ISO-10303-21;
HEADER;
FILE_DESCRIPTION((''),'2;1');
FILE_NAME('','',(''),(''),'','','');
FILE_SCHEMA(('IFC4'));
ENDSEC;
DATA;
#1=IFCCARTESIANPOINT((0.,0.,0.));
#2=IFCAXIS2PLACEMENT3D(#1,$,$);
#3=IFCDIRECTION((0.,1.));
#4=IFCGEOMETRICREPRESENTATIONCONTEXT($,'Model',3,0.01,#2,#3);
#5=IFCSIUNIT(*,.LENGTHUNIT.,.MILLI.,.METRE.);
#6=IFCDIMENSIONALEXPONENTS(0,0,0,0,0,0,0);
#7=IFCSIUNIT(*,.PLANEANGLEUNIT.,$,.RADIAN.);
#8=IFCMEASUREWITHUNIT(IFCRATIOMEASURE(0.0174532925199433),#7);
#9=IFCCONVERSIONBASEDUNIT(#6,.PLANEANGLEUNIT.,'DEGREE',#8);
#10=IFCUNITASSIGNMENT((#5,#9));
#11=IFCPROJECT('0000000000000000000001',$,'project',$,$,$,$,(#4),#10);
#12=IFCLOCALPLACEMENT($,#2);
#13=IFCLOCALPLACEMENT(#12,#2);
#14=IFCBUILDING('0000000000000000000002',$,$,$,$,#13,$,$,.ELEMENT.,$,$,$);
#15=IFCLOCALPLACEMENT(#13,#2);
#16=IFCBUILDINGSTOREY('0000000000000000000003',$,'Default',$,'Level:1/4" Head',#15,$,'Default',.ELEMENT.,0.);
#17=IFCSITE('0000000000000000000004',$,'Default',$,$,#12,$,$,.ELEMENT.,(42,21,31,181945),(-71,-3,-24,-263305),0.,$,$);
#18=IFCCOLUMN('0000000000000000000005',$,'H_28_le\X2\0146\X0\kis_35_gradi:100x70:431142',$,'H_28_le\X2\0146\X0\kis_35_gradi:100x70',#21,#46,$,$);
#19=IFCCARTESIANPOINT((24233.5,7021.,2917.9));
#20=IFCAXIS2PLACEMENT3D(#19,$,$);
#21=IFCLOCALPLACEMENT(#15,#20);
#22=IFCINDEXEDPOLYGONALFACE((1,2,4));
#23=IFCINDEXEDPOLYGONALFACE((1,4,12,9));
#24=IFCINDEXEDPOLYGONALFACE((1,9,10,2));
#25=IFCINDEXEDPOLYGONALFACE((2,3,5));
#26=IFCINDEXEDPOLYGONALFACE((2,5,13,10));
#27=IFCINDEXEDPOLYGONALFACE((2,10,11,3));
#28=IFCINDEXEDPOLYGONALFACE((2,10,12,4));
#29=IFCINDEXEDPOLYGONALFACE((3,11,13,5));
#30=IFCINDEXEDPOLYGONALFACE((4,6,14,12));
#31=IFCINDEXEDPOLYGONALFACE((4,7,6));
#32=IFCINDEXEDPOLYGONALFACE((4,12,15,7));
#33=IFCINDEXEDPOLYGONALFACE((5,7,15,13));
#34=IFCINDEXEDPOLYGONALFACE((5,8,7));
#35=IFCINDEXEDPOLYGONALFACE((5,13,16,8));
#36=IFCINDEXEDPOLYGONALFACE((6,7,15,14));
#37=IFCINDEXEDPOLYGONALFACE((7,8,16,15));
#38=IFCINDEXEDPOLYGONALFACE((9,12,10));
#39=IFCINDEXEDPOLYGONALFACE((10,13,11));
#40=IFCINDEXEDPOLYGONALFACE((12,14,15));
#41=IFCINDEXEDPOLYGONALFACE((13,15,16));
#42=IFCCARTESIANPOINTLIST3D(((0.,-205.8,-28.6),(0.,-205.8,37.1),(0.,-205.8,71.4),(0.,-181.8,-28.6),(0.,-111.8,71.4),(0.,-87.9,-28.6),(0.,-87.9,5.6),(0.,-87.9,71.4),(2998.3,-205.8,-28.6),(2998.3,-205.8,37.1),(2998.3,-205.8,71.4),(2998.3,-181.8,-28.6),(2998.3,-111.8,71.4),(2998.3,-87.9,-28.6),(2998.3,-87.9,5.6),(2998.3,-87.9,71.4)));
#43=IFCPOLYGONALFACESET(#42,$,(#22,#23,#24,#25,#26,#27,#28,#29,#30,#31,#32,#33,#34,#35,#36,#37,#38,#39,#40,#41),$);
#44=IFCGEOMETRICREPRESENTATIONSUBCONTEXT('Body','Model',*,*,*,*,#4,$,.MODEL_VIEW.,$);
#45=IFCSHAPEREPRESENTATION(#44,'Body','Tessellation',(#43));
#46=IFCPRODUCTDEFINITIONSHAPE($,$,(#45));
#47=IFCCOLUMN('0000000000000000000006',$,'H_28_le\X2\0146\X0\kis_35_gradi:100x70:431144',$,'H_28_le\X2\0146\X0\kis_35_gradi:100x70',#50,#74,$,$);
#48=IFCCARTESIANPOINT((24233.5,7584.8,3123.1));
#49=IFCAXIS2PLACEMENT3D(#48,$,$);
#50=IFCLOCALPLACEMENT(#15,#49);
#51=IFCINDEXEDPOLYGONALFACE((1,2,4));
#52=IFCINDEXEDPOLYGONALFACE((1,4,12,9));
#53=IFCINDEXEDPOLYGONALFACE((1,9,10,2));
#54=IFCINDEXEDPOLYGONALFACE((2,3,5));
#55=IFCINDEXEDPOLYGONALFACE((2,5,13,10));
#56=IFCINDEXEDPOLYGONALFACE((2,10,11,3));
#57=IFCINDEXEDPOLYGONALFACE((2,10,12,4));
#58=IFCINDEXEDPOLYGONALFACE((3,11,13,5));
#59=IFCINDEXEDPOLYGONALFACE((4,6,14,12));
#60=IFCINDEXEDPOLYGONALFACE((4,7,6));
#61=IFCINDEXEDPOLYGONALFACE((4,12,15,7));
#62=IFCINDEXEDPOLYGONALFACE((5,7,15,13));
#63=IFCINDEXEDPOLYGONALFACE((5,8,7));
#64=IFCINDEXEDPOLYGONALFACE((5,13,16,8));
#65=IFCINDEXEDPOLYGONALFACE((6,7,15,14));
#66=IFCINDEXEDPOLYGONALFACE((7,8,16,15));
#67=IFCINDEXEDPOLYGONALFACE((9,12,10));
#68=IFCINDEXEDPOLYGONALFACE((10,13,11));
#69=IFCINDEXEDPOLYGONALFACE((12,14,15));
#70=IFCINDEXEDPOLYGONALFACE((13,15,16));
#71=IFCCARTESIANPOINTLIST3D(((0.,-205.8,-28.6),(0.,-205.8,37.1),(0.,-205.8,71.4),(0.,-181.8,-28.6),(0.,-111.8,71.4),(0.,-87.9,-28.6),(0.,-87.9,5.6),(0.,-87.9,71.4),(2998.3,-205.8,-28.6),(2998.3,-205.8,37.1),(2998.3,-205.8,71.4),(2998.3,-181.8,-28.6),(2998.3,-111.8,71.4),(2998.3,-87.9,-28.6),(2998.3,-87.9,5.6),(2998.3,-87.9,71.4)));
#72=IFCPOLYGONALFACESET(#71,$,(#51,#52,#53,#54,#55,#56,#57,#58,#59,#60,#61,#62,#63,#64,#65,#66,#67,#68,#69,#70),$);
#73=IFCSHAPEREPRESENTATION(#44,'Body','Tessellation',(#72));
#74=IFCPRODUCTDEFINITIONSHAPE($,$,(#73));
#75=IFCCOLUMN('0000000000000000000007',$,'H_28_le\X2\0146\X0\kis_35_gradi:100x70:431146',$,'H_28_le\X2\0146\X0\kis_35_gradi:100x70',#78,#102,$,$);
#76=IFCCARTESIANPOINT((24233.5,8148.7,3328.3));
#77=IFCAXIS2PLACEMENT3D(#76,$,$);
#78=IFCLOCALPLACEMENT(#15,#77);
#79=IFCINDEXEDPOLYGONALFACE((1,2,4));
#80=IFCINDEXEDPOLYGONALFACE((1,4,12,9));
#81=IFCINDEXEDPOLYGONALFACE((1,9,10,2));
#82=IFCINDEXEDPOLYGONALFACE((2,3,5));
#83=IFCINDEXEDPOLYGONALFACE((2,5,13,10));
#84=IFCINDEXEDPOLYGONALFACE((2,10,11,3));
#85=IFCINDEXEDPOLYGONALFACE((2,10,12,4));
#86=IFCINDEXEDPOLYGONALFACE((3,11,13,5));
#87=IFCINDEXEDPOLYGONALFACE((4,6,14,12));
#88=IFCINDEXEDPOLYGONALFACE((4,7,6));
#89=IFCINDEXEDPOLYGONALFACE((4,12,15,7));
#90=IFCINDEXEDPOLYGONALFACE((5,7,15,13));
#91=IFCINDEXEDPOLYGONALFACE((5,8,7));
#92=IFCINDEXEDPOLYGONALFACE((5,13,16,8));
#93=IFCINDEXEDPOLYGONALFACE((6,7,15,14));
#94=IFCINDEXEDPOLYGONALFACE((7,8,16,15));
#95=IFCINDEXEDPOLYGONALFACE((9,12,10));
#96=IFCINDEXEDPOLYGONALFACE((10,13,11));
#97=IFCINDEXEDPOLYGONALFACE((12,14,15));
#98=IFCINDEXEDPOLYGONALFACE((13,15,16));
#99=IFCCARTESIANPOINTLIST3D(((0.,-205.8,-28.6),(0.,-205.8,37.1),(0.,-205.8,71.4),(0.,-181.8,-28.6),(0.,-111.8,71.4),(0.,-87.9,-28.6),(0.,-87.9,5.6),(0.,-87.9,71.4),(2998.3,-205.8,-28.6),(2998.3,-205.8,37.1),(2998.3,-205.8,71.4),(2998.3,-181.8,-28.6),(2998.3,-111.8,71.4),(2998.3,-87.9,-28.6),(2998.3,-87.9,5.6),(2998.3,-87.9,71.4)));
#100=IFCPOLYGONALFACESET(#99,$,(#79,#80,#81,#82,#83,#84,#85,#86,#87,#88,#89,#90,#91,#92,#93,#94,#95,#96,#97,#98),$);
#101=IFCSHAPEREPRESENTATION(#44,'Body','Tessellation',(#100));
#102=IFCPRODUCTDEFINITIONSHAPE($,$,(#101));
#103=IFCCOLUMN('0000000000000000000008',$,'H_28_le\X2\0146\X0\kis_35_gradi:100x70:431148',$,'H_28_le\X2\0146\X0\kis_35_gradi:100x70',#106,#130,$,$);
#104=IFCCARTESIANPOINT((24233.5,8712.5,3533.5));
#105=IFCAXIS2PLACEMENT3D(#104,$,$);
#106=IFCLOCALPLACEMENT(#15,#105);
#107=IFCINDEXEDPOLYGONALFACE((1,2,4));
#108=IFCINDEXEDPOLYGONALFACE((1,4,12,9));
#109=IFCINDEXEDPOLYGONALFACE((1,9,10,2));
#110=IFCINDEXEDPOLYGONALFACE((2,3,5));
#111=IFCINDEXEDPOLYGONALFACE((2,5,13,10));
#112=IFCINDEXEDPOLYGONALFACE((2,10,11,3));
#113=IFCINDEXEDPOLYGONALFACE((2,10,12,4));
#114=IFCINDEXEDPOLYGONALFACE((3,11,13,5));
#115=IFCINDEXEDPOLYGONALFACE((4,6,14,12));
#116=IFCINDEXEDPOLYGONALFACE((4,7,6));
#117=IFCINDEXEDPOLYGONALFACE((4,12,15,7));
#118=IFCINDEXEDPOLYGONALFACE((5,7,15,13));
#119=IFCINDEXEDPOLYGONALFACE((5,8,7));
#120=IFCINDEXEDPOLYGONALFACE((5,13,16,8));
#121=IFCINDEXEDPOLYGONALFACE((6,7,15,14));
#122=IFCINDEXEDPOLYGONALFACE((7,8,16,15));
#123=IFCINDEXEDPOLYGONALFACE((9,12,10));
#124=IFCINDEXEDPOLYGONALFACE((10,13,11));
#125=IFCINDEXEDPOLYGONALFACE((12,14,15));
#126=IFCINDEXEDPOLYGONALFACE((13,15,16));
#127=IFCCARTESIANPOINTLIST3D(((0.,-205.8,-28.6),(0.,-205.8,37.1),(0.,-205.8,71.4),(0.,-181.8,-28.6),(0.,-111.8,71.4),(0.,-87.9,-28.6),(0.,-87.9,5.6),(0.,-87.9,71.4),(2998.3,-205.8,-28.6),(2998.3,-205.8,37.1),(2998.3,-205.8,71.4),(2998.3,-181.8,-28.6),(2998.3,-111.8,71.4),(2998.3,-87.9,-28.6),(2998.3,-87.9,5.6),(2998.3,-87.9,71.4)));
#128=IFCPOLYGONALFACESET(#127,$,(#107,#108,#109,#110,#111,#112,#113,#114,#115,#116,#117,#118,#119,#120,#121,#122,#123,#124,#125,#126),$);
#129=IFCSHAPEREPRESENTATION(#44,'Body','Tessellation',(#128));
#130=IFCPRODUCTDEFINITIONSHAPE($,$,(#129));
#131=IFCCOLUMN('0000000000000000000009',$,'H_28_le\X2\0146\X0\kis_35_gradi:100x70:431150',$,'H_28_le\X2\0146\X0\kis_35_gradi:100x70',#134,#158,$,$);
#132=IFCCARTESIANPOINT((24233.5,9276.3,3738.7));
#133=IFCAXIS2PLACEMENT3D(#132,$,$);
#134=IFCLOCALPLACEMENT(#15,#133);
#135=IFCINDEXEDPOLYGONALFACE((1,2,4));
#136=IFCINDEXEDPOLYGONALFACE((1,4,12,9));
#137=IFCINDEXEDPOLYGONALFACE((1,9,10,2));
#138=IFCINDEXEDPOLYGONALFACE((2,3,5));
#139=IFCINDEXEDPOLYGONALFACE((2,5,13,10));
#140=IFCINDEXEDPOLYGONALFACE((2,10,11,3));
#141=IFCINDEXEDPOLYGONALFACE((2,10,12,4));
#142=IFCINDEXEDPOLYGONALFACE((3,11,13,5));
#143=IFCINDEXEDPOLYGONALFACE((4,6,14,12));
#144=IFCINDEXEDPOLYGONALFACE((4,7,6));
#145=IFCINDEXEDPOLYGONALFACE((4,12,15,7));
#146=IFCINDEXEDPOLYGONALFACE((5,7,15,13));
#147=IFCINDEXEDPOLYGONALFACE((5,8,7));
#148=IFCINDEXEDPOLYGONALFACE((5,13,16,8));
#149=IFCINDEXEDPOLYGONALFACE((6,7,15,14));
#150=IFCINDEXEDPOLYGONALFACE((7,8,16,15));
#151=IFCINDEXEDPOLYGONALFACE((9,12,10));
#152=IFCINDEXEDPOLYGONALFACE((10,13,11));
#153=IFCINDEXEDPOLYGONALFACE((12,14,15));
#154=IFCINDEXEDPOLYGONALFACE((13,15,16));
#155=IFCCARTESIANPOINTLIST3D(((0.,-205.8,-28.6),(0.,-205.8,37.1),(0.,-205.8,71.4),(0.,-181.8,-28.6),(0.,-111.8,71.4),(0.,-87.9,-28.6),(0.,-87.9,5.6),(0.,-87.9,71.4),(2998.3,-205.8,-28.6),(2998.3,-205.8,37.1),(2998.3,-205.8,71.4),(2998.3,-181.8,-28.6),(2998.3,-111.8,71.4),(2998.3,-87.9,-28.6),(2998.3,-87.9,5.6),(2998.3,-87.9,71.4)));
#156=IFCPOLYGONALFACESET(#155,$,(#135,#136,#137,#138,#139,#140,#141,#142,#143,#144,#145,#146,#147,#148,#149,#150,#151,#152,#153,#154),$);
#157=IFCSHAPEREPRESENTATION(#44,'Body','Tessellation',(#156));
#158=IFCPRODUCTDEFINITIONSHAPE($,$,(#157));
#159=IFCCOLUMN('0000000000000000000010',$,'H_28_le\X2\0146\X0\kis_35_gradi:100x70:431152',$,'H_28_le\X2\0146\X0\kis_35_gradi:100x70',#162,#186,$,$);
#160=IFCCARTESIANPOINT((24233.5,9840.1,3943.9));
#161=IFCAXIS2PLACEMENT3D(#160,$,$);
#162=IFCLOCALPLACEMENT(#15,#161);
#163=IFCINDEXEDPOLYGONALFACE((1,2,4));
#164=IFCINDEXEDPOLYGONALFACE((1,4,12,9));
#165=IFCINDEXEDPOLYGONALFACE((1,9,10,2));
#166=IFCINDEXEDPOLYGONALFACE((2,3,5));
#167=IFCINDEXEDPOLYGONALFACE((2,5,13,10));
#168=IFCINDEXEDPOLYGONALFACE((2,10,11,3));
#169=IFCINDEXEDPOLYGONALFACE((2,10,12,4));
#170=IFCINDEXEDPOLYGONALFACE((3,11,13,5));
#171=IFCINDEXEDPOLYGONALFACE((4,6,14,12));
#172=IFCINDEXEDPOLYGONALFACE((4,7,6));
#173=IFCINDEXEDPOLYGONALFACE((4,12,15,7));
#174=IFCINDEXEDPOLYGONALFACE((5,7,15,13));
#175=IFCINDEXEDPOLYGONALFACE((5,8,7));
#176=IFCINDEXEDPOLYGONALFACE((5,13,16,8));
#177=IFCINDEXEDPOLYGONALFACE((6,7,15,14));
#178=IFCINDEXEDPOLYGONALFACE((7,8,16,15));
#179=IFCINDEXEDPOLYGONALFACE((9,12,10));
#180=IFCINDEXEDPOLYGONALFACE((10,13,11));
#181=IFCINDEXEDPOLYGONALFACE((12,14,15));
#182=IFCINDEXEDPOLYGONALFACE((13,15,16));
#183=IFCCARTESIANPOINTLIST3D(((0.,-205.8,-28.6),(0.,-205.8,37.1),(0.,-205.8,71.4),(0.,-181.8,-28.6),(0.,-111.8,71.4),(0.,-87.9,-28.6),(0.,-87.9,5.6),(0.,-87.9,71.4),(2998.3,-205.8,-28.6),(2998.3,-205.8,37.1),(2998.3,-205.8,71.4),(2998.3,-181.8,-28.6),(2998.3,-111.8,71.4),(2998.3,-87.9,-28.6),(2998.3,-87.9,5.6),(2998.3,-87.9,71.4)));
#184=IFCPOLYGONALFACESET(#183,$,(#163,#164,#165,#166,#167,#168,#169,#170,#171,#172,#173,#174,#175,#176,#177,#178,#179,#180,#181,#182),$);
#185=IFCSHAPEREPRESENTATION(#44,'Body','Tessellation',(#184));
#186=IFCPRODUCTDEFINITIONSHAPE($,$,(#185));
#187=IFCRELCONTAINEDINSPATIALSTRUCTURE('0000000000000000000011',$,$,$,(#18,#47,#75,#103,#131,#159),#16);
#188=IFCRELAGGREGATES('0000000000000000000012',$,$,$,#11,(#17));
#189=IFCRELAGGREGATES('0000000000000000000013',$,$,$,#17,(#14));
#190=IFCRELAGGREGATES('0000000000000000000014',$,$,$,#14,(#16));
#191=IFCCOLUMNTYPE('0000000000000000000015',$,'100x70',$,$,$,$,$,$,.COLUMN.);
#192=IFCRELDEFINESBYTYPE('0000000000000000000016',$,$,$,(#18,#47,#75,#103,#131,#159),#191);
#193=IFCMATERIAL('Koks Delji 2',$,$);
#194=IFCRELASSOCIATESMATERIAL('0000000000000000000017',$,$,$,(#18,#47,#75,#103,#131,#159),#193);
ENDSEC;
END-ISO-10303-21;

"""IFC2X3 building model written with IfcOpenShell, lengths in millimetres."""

from ifc_helpers import new_model, entity, si_unit, converted_unit, direction, frame, frame_2d, origin, place, context, subcontext, project, spatial, rectangle, extrude, boolean, source, transform, mapped, material, type_object, type_shapes, element, save


model = new_model("IFC2X3")

# Units and contexts
model_context = context("Model", 3, precision=0.01, world=origin(), true_north=direction((0.0, 1.0)))
body_context = subcontext(model_context, "Body", "Model", "MODEL_VIEW")
ifc_project = project(units=[si_unit("LENGTHUNIT", "METRE", prefix="MILLI"), converted_unit("PLANEANGLEUNIT", "DEGREE", entity("IfcRatioMeasure", 0.0174532925199433), si_unit("PLANEANGLEUNIT", "RADIAN"), dimensions=[0, 0, 0, 0, 0, 0, 0])], contexts=[model_context])

# Site, building, storey
site_placement = place(None, origin())
site = spatial("IfcSite", under=ifc_project, at=site_placement, Name="Default", CompositionType="ELEMENT", RefLatitude=(42, 21, 31, 181945), RefLongitude=(-71, -3, -24, -263305), RefElevation=0.0)
building_placement = place(site_placement, origin())
building = spatial("IfcBuilding", under=site, at=building_placement, CompositionType="ELEMENT")
storey_placement = place(building_placement, origin())
storey = spatial("IfcBuildingStorey", under=building, at=storey_placement, Name="Default", ObjectType="Level:1/4\" Head", LongName="Default", CompositionType="ELEMENT", Elevation=0.0)

# Columns
ifc_material_1 = material(Name="Koks Delji 2")
column_type_1 = type_object("IfcColumnType", Name="100x70", PredefinedType="COLUMN")
shared_shape_1 = source(origin(), body_context, "Body", "CSG", [
    boolean("DIFFERENCE", extrude(rectangle(XDim=2998.3, YDim=117.9, at=frame_2d((0.0, 0.0), x_axis=(1.0, 0.0))), frame((1499.1, -146.8, -28.6)), (0.0, 0.0, 1.0), 100.0), extrude(rectangle(XDim=70.0, YDim=100.0, at=frame_2d((0.0, 0.0), x_axis=(0.0, 1.0))), frame((0.0, -146.8, 21.4), z_axis=(-1.0, 0.0, 0.0), x_axis=(0.0, -0.939693, -0.34202)), (0.0, 0.0, -1.0), 2998.3)),
])
type_shapes(column_type_1, [shared_shape_1])
for number, where, name in (
    (1, (24233.5, 7021.0, 2917.9), "H_28_leņkis_35_gradi:100x70:431142"),
    (2, (24233.5, 7584.8, 3123.1), "H_28_leņkis_35_gradi:100x70:431144"),
    (3, (24233.5, 8148.7, 3328.3), "H_28_leņkis_35_gradi:100x70:431146"),
    (4, (24233.5, 8712.5, 3533.5), "H_28_leņkis_35_gradi:100x70:431148"),
    (5, (24233.5, 9276.3, 3738.7), "H_28_leņkis_35_gradi:100x70:431150"),
    (6, (24233.5, 9840.1, 3943.9), "H_28_leņkis_35_gradi:100x70:431152"),
):
    element("IfcColumn", number, at=place(storey_placement, frame(where)), inside=storey, type_object=column_type_1, material=ifc_material_1, Name=name, ObjectType="H_28_leņkis_35_gradi:100x70", context=body_context, shape_type="MappedRepresentation", body=[
        mapped(shared_shape_1, transform((0.0, 0.0, 0.0), scale=1.0)),
    ])

save(model, "model.ifc")
